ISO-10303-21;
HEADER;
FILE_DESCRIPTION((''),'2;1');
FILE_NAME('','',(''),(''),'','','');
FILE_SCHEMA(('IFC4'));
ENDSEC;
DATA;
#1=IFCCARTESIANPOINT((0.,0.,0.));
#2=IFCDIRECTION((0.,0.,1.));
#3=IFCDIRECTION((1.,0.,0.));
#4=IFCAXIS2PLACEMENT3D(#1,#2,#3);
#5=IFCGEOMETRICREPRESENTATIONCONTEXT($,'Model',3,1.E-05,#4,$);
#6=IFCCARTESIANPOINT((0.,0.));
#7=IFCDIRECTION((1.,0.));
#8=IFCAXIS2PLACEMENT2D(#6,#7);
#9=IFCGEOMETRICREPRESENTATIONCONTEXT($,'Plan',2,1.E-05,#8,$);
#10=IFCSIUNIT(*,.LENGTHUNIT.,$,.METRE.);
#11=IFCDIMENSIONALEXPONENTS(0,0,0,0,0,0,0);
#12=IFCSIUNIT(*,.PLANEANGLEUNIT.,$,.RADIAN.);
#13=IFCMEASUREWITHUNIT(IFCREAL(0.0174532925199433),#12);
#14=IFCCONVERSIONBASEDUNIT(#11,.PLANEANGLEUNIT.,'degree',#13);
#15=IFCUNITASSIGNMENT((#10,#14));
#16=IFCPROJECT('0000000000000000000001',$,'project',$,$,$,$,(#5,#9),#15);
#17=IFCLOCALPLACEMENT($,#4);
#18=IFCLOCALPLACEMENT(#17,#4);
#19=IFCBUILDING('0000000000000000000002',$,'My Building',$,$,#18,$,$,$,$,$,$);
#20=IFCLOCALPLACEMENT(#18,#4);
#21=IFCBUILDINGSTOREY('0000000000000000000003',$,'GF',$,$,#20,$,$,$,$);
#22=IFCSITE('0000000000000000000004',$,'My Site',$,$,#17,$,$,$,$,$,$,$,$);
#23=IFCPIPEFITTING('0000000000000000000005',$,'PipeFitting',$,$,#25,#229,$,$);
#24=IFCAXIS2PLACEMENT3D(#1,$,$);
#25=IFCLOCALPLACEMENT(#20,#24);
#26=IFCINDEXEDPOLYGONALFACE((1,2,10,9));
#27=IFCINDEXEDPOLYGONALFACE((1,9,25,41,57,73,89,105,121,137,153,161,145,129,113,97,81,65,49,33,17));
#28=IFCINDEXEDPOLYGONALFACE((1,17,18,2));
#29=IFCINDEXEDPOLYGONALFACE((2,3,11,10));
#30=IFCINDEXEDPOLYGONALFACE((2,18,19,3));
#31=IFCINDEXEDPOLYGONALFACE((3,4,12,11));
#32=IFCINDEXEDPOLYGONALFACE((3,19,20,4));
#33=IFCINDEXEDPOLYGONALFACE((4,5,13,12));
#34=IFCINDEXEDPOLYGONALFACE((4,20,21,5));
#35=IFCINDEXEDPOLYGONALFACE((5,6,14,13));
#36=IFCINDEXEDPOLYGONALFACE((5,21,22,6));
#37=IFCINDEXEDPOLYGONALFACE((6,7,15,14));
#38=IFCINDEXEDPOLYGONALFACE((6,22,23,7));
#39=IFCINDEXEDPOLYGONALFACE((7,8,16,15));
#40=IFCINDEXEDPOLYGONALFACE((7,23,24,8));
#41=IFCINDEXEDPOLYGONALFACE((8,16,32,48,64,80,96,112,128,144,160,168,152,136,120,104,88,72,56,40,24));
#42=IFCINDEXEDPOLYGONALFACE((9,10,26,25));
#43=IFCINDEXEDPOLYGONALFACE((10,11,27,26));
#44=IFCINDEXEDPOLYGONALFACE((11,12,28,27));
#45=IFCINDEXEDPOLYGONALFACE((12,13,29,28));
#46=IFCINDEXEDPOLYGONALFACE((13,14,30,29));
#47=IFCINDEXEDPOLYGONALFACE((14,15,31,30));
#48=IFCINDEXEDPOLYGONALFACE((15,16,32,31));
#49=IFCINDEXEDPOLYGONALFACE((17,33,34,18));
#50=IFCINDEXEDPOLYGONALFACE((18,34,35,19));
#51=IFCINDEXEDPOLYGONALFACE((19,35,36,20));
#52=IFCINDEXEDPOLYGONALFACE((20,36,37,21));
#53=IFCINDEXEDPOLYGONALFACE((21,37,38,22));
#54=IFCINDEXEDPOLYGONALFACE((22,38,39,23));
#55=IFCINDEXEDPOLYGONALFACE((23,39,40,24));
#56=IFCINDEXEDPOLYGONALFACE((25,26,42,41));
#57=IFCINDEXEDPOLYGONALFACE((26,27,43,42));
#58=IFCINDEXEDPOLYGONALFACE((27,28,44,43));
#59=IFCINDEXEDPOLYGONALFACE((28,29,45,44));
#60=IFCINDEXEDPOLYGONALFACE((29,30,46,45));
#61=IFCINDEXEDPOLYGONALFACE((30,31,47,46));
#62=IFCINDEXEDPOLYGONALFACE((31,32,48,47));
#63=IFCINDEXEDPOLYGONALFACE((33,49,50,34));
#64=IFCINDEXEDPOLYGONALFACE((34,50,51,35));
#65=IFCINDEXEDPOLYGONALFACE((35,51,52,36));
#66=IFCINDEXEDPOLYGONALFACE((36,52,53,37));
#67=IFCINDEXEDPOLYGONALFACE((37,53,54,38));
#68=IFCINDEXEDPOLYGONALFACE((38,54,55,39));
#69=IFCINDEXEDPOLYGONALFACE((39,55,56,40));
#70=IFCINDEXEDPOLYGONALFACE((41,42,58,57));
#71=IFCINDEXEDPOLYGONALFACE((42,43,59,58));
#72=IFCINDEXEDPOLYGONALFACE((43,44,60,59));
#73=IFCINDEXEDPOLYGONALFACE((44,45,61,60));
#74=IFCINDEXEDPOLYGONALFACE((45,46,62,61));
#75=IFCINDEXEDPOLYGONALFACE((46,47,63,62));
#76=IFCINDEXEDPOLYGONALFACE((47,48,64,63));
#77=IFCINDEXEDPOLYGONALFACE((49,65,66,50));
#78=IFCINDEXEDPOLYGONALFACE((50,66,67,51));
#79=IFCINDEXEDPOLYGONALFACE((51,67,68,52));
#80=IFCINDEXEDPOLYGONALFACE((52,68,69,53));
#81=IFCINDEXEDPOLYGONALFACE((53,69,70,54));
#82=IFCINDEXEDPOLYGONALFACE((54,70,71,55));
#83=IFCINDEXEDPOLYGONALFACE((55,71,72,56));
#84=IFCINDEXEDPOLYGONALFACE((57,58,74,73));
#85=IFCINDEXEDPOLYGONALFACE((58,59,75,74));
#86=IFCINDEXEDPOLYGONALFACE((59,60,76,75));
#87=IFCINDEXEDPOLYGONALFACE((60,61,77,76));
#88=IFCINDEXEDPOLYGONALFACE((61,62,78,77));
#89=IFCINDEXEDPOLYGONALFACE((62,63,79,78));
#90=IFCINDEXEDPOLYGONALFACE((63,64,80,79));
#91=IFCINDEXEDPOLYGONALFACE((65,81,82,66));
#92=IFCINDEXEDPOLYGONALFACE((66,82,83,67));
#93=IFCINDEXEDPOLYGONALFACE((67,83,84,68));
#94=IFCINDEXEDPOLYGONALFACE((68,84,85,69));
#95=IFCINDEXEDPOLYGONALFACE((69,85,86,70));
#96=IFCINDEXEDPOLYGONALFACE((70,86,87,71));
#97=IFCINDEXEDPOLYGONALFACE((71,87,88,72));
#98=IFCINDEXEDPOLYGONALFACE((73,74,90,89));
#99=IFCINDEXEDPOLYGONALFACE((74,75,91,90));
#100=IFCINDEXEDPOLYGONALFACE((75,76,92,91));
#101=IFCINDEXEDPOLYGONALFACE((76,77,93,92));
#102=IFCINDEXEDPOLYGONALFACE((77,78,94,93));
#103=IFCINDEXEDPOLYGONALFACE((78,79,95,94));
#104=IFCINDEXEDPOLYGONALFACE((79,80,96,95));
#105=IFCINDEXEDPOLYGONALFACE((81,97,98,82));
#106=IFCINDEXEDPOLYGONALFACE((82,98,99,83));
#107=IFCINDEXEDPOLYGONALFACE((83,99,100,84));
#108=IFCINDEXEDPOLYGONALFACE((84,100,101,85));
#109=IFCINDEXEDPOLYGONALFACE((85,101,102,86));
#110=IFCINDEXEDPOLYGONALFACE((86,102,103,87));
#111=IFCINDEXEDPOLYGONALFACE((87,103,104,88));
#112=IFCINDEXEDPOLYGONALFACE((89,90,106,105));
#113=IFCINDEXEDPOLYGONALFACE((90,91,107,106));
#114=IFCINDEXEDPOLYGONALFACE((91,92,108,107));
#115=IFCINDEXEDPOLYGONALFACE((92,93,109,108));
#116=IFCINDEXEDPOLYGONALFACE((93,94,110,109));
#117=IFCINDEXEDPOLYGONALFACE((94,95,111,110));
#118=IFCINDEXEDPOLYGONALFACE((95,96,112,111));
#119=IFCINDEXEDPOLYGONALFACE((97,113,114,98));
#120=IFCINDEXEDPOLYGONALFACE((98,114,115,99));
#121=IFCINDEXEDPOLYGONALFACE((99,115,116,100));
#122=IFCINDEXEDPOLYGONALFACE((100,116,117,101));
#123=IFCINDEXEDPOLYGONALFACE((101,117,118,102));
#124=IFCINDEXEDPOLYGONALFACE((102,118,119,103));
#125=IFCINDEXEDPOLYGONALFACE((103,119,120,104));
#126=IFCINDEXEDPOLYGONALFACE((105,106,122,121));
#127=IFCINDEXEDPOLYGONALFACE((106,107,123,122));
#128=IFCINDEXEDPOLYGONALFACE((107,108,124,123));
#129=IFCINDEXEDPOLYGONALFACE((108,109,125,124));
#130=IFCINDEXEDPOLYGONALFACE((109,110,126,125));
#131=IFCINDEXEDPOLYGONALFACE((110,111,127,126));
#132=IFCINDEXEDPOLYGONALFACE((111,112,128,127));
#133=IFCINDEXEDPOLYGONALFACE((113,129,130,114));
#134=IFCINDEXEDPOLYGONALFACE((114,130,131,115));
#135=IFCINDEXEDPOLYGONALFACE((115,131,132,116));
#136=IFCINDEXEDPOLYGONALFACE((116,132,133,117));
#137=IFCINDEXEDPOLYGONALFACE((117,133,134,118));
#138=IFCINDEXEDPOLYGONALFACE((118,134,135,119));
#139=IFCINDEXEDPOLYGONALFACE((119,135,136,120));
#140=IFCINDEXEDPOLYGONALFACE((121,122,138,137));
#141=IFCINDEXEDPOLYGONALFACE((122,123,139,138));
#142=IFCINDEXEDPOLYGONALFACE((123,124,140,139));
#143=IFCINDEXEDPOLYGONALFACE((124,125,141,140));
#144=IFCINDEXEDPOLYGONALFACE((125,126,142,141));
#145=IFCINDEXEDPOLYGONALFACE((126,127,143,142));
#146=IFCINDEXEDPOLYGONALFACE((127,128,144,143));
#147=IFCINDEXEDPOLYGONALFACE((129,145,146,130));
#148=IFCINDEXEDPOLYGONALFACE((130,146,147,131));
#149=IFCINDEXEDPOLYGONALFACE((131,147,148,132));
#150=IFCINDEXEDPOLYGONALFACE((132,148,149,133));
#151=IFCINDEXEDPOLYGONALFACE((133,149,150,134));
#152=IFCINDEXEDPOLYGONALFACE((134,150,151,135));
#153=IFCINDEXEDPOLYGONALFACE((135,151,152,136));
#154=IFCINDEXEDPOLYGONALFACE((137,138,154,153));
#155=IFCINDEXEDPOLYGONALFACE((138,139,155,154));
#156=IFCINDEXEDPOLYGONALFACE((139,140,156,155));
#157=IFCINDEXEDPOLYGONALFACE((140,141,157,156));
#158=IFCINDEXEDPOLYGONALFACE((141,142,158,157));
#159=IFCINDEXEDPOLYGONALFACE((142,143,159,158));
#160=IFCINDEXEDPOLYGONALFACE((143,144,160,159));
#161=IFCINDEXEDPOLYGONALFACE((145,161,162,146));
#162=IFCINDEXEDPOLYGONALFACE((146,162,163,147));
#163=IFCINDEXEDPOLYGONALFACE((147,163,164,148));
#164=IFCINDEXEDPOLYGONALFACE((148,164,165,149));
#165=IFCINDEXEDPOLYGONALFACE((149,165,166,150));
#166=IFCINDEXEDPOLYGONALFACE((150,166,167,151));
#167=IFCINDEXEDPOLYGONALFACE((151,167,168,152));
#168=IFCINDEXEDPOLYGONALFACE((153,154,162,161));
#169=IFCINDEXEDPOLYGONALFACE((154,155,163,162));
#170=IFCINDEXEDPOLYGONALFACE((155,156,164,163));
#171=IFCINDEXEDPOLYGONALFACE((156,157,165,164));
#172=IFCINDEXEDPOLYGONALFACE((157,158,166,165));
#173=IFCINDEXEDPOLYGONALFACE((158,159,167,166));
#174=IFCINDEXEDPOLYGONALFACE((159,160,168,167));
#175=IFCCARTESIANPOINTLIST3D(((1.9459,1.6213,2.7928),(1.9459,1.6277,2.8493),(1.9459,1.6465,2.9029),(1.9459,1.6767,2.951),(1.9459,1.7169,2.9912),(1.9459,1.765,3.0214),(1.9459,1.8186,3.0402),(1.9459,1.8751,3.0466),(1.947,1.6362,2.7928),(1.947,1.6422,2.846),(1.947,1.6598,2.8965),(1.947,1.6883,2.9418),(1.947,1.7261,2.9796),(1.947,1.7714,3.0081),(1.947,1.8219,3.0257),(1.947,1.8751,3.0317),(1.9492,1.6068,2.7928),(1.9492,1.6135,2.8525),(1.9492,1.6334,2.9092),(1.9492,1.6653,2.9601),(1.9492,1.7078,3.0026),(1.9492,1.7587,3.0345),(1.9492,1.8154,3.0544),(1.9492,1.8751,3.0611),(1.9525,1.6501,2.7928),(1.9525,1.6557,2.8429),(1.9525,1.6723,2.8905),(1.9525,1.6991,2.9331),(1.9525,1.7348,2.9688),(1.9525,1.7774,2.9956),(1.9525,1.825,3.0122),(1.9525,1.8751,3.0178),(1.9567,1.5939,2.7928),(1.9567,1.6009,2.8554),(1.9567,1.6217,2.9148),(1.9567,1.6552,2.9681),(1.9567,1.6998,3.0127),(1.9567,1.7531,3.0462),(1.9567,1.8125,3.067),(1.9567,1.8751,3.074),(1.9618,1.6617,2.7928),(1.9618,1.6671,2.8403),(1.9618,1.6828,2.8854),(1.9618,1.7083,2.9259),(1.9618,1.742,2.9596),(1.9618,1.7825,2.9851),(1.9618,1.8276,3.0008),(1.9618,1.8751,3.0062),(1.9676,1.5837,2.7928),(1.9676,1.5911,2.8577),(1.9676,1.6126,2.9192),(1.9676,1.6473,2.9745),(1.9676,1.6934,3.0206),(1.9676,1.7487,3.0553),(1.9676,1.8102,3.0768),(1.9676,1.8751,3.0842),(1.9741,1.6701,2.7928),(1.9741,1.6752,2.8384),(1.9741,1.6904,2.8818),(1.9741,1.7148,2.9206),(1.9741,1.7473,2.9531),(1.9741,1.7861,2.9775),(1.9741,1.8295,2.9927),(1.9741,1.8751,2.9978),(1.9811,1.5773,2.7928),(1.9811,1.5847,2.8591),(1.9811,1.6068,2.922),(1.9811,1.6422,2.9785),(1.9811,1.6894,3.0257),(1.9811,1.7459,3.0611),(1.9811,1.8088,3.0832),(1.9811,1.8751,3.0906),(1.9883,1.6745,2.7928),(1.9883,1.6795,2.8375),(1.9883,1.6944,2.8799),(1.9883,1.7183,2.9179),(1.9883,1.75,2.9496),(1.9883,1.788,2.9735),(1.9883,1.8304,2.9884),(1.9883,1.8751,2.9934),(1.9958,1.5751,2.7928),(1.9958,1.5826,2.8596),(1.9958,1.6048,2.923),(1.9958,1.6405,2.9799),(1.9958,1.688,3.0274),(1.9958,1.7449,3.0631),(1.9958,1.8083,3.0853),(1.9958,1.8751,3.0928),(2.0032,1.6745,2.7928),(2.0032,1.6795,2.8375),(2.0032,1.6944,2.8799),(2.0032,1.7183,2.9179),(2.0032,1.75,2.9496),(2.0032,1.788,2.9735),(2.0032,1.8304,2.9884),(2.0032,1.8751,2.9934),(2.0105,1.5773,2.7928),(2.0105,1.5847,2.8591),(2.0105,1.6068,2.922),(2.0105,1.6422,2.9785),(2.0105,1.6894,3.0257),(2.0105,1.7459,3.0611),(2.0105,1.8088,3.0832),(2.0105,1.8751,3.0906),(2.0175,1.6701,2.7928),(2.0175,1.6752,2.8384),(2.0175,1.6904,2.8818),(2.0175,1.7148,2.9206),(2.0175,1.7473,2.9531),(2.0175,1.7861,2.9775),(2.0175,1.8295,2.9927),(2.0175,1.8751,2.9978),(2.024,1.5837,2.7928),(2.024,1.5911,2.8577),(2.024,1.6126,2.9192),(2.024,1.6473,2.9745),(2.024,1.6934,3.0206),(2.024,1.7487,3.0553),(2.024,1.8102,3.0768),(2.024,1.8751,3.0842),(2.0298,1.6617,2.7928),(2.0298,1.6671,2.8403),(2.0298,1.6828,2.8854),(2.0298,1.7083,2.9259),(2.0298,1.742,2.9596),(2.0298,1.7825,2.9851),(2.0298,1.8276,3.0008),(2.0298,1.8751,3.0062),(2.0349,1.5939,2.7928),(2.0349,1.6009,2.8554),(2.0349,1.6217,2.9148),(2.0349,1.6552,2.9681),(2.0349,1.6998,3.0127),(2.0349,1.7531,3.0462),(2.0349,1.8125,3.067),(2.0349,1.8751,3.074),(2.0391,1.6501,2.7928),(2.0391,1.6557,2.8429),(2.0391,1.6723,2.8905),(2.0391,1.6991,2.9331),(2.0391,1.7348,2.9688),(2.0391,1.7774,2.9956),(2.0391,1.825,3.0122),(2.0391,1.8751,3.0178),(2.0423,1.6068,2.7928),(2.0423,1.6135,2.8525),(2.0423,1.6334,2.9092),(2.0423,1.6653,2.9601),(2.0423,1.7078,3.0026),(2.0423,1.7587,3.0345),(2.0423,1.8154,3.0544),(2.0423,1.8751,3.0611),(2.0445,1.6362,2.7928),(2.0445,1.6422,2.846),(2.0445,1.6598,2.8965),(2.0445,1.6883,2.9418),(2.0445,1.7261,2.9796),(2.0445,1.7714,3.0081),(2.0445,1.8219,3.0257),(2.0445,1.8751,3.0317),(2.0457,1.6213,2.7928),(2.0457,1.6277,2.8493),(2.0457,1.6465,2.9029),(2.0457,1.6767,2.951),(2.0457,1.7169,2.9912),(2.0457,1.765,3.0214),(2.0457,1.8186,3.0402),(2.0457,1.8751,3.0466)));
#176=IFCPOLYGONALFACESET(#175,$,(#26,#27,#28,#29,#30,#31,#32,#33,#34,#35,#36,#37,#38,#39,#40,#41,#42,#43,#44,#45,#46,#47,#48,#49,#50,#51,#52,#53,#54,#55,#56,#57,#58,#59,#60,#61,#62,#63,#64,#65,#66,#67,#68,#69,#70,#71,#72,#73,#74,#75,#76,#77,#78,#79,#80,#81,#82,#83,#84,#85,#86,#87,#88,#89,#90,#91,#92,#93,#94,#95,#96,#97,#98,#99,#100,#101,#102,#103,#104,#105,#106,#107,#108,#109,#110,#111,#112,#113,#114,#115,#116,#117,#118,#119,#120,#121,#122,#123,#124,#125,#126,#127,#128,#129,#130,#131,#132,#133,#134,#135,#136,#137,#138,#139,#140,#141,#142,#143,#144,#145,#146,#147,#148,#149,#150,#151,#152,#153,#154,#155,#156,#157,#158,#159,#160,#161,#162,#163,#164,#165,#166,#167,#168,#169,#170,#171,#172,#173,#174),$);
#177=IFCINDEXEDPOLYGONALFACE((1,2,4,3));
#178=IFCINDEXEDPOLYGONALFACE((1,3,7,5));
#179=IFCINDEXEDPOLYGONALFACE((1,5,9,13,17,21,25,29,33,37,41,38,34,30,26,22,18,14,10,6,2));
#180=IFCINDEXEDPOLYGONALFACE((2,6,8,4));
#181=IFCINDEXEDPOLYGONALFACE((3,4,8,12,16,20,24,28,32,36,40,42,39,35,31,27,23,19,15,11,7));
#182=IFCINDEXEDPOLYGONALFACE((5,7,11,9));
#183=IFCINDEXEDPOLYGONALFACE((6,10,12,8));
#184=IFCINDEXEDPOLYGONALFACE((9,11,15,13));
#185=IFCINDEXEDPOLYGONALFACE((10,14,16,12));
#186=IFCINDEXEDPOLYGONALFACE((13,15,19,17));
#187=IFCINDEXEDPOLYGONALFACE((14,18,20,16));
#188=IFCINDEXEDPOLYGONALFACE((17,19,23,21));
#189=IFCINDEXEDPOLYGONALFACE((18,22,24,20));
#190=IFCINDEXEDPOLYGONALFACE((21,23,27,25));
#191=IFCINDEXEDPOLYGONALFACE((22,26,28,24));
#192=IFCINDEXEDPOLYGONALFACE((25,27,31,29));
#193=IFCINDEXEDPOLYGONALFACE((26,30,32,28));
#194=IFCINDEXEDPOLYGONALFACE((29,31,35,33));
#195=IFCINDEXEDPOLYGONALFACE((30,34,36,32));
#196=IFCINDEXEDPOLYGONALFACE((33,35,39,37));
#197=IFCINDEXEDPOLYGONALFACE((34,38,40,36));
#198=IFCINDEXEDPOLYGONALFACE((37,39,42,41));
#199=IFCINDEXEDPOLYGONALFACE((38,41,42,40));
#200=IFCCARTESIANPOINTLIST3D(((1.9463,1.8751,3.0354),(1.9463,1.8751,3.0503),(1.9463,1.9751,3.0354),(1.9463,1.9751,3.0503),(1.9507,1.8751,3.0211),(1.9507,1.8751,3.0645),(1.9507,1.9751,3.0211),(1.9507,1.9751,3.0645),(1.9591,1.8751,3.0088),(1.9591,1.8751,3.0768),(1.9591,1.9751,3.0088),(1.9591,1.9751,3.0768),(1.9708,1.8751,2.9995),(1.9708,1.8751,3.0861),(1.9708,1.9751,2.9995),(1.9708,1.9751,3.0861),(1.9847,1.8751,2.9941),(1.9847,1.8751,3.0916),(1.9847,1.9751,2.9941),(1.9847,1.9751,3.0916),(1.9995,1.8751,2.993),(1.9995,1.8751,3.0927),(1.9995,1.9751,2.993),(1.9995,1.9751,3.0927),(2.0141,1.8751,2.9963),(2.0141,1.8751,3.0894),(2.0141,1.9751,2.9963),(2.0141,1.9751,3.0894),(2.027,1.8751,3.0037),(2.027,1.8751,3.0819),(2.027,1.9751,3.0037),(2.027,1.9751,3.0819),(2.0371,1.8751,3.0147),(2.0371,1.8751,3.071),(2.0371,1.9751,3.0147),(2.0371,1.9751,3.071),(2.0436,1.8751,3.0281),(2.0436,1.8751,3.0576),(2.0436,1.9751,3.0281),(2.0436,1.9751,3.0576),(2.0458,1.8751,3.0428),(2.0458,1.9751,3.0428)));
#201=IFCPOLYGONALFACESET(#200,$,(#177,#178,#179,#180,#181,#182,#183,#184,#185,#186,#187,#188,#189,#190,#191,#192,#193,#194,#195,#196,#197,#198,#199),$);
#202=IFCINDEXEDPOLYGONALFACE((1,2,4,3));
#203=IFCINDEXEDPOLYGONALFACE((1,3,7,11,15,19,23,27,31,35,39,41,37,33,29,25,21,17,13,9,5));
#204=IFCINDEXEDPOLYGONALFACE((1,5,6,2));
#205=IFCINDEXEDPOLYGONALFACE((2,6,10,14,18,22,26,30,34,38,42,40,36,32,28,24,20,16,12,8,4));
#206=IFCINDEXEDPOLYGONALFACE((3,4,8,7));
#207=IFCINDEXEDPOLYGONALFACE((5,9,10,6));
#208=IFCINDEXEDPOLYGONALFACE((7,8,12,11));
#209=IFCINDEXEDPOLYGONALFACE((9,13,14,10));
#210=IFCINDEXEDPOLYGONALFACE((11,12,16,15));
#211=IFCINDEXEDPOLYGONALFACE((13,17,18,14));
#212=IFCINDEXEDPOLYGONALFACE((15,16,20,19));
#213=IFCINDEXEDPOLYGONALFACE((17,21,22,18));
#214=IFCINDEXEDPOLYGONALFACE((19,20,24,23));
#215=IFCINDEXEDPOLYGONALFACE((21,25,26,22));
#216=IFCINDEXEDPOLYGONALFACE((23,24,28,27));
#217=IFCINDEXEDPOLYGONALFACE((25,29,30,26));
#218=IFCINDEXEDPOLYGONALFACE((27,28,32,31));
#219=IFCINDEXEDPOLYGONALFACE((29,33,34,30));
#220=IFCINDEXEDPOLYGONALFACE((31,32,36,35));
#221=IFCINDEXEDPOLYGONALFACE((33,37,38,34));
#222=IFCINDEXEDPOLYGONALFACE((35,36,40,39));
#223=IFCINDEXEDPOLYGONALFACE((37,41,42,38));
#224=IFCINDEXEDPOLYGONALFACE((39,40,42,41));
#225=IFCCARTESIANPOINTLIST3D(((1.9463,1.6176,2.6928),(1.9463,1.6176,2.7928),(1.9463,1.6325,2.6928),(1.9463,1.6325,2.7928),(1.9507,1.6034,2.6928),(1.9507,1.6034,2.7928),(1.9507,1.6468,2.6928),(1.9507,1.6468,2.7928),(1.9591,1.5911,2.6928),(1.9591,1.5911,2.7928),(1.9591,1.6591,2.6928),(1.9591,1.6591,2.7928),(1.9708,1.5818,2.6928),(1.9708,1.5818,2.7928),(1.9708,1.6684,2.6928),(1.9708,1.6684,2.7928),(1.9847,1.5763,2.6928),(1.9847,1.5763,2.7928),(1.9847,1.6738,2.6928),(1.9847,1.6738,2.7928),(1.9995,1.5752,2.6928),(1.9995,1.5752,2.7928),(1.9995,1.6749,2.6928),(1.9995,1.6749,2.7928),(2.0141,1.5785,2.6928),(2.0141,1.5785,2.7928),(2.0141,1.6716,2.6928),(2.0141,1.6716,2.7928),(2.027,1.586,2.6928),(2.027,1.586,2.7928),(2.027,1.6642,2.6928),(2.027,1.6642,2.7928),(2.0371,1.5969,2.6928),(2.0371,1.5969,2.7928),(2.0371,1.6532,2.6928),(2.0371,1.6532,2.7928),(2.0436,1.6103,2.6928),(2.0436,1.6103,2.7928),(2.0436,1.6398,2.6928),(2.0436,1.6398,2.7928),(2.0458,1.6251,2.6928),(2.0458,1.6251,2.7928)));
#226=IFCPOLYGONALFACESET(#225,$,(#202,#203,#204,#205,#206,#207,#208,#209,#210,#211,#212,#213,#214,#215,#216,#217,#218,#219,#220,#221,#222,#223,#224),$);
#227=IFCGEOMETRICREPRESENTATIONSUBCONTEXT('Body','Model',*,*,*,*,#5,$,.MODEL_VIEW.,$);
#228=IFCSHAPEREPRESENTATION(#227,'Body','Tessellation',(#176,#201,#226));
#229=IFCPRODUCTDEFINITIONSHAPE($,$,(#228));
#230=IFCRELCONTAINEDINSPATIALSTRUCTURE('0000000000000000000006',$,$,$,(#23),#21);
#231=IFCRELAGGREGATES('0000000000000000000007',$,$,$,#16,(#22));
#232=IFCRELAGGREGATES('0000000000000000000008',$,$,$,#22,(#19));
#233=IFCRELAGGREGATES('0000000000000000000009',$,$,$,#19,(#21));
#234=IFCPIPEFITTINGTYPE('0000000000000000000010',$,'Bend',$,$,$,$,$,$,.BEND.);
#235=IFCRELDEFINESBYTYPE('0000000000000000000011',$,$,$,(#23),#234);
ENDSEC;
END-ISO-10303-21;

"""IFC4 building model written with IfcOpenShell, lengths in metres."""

from ifc_helpers import new_model, entity, si_unit, converted_unit, frame, origin_with_axes, origin_2d_with_axis, place, context, subcontext, project, spatial, line, indexed_curve, circle, outline, extrude, source, transform, mapped, type_object, type_shapes, element, save


model = new_model("IFC4")

# Units and contexts
model_context = context("Model", 3, precision=1e-05, world=origin_with_axes())
plan_context = context("Plan", 2, precision=1e-05, world=origin_2d_with_axis())
body_context_1 = subcontext(model_context, "Body", "Model", "MODEL_VIEW")
ifc_project = project(units=[si_unit("LENGTHUNIT", "METRE"), converted_unit("PLANEANGLEUNIT", "degree", entity("IfcReal", 0.0174532925199433), si_unit("PLANEANGLEUNIT", "RADIAN"), dimensions=[0, 0, 0, 0, 0, 0, 0])], contexts=[model_context, plan_context])

# Site, building, storey
site_placement = place(None, origin_with_axes())
site = spatial("IfcSite", under=ifc_project, at=site_placement, Name="My Site")
building_placement = place(site_placement, origin_with_axes())
building = spatial("IfcBuilding", under=site, at=building_placement, Name="My Building")
storey_placement = place(building_placement, origin_with_axes())
storey = spatial("IfcBuildingStorey", under=building, at=storey_placement, Name="GF")

# Pipe fitting, opening
pipe_fitting_type = type_object("IfcPipeFittingType", Name="Bend", PredefinedType="BEND")
shared_shape_1 = source(origin_with_axes(), body_context_1, "Body", "SolidModel", [
    entity("IfcSweptDiskSolid", entity("IfcIndexedPolyCurve", entity("IfcCartesianPointList3D", [[0.0, 0.0, 0.1], [0.0, -0.0732, 0.2768], [0.0, -0.25, 0.35]]), [entity("IfcArcIndex", [1, 2, 3])]), 0.05),
    extrude(circle(Radius=0.05), origin_with_axes(), (0.0, 0.0, 1.0), 0.1),
    extrude(circle(Radius=0.05), frame((0.0, -0.25, 0.35), z_axis=(0.0, -1.0, 0.0), x_axis=(1.0, 0.0, 0.0)), (0.0, 0.0, 1.0), 0.1),
])
type_shapes(pipe_fitting_type, [shared_shape_1])
pipe_fitting_1_placement = place(storey_placement, frame((1.9958, 1.9751, 3.0428), z_axis=(0.0, -1.0, 0.0), x_axis=(1.0, 0.0, 0.0)))
pipe_fitting_1 = element("IfcPipeFitting", 1, at=pipe_fitting_1_placement, inside=storey, type_object=pipe_fitting_type, Name="PipeFitting", context=body_context_1, shape_type="MappedRepresentation", body=[
    mapped(shared_shape_1, transform((0.0, 0.0, 0.0), x_axis=(1.0, 0.0, 0.0), y_axis=(0.0, 1.0, 0.0), z_axis=(0.0, 0.0, 1.0), scale=1.0)),
])
opening_1_placement = place(pipe_fitting_1_placement, frame((-1.9958, -3.0428, 1.9751), z_axis=(0.0, 1.0, 0.0), x_axis=(1.0, 0.0, 0.0)))
element("IfcOpeningElement", 2, at=opening_1_placement, cuts=pipe_fitting_1, PredefinedType="OPENING", context=body_context_1, shape_type="SweptSolid", body=[
    extrude(outline(indexed_curve([(0.0, 0.0), (0.5, 0.0), (0.5, 0.5), (0.0, 0.5)], segments=[line(1, 2, 3, 4, 1)])), origin_with_axes(), (0.0, 0.0, 1.0), 0.5),
])

save(model, "model.ifc")
